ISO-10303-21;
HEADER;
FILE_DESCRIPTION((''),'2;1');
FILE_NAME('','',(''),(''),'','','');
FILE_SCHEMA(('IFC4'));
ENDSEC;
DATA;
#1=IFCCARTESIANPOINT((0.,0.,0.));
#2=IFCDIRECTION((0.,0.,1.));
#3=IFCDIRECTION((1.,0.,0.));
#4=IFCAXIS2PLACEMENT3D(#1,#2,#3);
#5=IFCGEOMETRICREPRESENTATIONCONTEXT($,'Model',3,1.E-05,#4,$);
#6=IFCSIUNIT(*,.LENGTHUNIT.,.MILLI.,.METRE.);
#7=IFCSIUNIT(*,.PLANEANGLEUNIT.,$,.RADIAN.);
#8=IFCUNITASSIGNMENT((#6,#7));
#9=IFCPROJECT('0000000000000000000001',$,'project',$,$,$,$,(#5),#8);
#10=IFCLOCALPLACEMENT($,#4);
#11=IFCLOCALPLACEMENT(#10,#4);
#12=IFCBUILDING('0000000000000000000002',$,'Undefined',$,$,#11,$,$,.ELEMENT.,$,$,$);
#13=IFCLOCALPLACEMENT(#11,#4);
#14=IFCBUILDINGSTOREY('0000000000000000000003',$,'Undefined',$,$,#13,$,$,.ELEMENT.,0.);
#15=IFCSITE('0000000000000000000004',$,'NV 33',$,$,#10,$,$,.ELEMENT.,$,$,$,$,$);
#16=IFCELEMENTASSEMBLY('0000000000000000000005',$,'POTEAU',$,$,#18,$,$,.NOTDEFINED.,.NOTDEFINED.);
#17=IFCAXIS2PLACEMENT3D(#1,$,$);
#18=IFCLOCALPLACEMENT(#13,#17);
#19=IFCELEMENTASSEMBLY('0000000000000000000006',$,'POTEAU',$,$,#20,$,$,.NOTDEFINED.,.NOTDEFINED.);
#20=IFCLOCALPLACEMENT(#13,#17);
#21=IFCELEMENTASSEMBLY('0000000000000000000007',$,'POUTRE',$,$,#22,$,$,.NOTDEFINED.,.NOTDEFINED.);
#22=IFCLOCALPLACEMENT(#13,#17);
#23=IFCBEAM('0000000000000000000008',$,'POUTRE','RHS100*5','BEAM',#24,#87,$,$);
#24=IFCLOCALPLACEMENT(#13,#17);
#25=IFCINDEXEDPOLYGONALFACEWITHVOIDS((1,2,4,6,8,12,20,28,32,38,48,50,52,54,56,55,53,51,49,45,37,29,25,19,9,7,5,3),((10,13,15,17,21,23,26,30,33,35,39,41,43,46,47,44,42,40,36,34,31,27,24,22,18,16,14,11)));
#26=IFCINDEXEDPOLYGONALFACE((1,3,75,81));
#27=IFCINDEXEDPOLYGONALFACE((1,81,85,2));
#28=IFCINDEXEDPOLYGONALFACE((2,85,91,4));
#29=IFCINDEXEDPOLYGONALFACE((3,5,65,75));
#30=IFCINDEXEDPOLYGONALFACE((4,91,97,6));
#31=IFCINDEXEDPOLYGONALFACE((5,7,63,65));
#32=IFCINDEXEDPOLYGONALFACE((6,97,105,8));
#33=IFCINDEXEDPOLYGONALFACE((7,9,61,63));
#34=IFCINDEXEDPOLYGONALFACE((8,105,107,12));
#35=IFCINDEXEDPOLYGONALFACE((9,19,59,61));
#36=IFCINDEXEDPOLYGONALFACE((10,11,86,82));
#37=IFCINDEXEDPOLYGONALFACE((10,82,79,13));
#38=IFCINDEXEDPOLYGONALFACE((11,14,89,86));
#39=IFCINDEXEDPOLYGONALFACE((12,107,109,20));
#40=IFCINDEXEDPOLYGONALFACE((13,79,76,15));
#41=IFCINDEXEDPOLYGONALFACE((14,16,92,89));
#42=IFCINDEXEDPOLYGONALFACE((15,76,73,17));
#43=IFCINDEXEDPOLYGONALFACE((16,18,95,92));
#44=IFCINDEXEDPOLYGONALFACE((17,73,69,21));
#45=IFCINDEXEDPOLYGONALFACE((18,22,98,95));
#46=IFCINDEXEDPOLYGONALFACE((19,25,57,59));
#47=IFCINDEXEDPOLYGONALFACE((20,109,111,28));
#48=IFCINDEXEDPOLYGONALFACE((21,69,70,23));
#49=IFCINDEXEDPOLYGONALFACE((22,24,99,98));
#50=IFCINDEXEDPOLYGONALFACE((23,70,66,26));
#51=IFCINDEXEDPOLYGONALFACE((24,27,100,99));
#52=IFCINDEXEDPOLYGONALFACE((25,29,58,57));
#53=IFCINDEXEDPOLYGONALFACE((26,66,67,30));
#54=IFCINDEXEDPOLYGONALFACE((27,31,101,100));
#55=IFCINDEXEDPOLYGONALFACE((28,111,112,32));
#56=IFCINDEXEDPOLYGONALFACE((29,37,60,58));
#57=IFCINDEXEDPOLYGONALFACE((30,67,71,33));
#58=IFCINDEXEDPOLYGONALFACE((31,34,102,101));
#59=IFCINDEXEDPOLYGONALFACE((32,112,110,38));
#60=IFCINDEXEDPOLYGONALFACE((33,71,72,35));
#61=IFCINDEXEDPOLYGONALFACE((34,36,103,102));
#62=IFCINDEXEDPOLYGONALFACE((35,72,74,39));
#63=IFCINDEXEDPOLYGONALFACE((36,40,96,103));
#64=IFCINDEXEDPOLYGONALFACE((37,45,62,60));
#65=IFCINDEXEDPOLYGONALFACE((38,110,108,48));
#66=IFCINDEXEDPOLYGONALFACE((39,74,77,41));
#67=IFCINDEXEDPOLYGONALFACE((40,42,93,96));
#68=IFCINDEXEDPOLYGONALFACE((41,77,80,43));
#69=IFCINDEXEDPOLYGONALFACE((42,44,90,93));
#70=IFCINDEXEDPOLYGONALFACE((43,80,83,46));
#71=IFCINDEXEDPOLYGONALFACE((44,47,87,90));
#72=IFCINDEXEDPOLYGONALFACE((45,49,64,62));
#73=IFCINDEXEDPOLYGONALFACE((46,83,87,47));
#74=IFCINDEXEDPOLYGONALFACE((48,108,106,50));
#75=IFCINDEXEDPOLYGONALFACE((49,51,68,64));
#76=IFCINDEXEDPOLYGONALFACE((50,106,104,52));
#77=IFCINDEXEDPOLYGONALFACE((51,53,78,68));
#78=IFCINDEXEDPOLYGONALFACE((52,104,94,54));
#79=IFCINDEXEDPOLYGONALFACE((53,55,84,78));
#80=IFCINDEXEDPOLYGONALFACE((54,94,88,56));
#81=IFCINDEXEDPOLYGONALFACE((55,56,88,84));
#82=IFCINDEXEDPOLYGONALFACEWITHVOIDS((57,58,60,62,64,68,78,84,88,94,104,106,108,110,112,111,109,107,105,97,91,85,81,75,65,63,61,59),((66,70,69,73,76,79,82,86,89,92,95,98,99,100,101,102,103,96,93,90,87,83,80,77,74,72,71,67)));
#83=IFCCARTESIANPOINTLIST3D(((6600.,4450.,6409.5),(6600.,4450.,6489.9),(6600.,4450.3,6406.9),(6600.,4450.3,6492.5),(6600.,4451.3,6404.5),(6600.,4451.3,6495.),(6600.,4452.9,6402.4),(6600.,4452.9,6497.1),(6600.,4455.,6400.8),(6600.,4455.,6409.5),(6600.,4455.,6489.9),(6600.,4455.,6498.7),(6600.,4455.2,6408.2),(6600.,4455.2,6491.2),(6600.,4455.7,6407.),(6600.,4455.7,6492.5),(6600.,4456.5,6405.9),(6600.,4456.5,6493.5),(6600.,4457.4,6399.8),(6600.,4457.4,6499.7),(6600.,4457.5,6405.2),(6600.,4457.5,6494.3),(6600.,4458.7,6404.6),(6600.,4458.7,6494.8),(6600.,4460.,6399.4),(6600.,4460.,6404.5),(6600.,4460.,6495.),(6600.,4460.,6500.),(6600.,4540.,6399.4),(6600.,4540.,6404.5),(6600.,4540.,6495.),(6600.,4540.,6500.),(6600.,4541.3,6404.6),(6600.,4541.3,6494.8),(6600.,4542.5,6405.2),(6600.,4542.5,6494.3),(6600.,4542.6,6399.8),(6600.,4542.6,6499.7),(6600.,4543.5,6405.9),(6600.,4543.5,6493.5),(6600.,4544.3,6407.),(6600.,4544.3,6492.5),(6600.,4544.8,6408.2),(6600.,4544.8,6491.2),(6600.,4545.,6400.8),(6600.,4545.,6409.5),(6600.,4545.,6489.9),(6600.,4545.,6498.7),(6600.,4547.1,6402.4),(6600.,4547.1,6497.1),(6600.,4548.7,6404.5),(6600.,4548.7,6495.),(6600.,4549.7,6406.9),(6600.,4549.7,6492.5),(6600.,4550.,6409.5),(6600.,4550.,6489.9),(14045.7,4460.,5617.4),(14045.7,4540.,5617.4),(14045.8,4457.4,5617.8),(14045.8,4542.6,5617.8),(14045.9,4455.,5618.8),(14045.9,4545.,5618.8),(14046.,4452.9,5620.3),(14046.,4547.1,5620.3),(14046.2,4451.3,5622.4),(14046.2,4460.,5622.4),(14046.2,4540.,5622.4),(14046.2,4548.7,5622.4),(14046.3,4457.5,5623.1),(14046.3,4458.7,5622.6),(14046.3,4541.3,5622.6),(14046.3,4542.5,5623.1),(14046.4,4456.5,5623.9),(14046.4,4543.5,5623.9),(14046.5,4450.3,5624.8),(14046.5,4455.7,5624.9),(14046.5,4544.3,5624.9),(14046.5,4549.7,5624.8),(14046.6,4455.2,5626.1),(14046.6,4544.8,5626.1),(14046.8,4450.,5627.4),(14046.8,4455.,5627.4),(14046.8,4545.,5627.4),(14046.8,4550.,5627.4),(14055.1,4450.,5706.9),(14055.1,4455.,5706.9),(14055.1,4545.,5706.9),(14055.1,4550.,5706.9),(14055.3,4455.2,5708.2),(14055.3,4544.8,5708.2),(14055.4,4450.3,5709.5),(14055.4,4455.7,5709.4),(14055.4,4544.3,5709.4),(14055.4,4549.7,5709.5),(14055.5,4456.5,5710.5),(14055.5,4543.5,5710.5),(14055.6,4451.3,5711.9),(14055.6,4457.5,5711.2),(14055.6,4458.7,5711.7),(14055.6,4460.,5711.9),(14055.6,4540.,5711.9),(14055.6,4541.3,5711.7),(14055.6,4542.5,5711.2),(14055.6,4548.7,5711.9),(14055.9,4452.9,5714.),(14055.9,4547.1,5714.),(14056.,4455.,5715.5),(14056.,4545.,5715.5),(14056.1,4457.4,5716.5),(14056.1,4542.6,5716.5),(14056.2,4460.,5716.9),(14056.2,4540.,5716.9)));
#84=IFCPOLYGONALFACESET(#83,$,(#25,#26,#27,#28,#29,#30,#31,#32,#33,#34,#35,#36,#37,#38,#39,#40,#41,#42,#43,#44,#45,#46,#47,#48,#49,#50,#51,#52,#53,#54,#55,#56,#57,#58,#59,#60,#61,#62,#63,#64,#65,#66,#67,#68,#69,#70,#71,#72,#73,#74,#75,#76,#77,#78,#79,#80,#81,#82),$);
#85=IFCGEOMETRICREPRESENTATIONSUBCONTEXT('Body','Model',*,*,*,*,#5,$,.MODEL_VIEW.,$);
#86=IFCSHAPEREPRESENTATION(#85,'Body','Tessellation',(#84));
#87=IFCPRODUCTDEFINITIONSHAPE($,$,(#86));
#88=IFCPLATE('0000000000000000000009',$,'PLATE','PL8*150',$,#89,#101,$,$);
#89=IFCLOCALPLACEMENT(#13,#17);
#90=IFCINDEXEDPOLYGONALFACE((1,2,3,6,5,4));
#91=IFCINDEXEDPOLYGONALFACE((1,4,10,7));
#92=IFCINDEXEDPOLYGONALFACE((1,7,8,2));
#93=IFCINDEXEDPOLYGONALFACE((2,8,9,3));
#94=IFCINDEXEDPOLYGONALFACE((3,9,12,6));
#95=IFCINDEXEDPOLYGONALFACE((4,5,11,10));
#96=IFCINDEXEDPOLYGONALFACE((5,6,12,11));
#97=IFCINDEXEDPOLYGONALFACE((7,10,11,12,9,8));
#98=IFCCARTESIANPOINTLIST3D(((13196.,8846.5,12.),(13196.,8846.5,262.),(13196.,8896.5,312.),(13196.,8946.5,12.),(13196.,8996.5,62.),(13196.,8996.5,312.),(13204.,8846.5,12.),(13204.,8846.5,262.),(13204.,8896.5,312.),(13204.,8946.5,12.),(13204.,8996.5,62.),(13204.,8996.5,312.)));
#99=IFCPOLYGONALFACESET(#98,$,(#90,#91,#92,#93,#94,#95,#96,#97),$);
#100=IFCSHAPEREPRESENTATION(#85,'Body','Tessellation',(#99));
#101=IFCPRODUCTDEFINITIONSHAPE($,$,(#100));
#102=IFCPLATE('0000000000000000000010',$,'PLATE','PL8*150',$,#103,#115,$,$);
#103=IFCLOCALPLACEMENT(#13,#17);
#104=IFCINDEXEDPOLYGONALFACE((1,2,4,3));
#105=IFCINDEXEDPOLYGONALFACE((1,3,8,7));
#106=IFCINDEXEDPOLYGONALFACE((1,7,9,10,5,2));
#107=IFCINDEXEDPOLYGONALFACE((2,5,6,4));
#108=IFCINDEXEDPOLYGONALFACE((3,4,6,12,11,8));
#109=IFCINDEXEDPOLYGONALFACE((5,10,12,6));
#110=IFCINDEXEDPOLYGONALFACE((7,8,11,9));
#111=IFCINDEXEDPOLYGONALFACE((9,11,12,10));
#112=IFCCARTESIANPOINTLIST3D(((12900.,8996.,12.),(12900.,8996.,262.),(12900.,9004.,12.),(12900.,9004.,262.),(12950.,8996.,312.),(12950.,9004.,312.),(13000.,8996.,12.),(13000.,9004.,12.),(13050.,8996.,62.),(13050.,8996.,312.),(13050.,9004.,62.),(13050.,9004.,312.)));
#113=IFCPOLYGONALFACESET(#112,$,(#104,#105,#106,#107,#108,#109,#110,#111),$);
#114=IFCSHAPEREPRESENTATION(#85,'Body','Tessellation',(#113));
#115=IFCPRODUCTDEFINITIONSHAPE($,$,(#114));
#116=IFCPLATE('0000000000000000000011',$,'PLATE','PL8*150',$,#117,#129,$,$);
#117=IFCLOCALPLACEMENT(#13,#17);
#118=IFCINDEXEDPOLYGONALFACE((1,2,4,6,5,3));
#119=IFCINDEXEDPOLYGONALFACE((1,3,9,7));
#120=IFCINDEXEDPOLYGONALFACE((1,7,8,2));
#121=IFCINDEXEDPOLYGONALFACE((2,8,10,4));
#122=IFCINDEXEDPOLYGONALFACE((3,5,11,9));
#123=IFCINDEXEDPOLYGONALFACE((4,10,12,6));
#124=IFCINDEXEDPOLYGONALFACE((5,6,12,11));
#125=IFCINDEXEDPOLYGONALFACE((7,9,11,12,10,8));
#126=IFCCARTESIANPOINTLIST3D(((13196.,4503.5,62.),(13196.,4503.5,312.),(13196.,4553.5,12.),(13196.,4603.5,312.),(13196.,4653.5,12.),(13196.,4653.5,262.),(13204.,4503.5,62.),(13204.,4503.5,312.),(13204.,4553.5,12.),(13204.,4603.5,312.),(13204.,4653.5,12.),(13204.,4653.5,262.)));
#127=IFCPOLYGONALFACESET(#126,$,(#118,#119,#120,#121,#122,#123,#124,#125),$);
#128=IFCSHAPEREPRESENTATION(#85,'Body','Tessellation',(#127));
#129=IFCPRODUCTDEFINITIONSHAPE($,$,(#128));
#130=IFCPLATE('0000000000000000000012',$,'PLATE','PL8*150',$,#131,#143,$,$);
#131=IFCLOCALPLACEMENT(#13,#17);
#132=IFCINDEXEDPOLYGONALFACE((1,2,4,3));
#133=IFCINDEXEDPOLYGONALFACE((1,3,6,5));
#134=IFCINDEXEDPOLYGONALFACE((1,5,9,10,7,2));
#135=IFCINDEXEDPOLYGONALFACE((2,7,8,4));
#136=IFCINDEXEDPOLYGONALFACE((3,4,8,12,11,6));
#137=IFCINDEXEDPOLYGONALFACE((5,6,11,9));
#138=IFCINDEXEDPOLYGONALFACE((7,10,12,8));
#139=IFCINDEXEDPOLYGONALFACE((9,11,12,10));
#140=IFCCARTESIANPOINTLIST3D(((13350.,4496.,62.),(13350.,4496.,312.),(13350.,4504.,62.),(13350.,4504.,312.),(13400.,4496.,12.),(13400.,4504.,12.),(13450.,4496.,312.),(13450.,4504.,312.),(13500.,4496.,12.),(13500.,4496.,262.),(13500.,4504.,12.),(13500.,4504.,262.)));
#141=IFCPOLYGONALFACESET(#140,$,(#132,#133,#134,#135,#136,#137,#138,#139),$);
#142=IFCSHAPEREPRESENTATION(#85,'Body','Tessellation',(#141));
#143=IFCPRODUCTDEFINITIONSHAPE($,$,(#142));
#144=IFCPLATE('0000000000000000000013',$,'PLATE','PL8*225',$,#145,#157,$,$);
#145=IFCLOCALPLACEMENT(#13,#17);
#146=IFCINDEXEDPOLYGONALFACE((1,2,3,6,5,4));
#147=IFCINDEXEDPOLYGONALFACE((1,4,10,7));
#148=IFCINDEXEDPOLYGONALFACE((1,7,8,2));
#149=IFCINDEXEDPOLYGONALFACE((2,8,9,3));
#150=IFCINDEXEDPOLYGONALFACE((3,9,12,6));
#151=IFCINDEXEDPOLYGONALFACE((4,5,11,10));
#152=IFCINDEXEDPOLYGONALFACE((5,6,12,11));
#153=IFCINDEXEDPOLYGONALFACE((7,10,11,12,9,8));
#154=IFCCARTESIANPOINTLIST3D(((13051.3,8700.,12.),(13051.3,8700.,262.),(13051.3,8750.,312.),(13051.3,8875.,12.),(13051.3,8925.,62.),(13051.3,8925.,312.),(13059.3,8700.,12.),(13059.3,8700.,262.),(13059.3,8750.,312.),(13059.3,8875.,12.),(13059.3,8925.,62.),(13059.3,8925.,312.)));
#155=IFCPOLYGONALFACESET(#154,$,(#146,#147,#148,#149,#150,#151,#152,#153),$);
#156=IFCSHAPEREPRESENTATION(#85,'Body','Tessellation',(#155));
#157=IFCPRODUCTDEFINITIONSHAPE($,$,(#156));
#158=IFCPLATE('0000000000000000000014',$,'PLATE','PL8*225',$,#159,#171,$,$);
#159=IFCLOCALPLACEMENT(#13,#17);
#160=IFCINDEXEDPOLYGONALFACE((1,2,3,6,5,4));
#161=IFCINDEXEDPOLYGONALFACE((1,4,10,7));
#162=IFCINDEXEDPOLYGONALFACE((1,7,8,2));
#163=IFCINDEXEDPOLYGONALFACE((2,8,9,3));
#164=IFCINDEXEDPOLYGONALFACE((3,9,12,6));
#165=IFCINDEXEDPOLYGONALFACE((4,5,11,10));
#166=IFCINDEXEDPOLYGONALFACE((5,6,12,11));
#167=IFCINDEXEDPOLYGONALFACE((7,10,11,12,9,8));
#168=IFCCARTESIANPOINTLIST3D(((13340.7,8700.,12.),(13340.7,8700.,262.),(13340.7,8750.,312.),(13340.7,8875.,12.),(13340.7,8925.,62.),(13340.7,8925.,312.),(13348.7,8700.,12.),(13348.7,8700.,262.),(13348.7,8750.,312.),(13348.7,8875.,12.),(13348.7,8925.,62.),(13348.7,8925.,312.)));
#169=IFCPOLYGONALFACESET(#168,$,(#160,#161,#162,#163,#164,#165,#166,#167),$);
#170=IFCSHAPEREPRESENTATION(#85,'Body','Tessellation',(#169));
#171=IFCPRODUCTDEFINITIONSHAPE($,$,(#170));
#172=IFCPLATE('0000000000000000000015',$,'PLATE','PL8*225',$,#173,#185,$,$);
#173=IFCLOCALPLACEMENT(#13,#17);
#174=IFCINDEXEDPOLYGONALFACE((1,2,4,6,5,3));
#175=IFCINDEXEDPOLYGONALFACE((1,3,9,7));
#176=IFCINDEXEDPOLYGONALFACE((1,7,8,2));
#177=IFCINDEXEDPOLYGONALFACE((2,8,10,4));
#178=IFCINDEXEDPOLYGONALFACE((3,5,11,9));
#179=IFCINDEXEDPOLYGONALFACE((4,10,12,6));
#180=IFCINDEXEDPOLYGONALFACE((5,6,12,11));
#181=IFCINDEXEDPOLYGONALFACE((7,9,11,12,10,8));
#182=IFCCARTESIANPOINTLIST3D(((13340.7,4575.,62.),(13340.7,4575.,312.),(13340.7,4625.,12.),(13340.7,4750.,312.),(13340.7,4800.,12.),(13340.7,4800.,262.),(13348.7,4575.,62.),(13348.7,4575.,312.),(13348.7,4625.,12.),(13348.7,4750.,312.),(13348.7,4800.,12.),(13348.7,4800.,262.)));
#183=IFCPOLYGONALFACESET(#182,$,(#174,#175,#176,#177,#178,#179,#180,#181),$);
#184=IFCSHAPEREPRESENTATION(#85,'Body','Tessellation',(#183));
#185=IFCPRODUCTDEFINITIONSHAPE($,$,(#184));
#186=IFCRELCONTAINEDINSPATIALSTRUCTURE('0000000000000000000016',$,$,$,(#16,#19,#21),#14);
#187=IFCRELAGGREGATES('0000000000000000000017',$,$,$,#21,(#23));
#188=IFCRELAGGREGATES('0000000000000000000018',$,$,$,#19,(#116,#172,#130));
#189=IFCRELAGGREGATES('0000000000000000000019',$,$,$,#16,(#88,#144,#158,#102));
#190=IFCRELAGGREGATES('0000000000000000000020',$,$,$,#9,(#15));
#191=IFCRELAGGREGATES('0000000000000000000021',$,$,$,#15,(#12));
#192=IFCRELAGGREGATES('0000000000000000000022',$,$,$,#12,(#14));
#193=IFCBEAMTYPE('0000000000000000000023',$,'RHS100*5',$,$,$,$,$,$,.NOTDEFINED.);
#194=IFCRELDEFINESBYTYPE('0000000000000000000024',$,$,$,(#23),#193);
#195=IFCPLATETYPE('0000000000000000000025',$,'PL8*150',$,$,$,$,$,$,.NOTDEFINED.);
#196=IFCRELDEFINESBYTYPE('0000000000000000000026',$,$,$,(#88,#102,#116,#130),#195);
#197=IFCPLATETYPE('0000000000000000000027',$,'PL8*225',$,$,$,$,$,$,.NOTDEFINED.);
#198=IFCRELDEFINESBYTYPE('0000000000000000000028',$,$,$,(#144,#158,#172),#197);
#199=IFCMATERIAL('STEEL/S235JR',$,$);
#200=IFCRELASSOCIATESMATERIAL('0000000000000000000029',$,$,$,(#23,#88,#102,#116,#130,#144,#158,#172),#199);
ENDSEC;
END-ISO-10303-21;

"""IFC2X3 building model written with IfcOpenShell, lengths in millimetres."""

from ifc_helpers import new_model, si_unit, frame, origin_with_axes, origin_2d_with_axis, place, context, subcontext, project, spatial, polyline, hollow_rectangle, outline, extrude, clip, halfspace, material, type_object, element, aggregate, save


model = new_model("IFC2X3")

# Units and contexts
model_context = context("Model", 3, precision=1e-05, world=origin_with_axes())
body_context = subcontext(model_context, "Body", "Model", "MODEL_VIEW")
ifc_project = project(units=[si_unit("LENGTHUNIT", "METRE", prefix="MILLI"), si_unit("PLANEANGLEUNIT", "RADIAN")], contexts=[model_context])

# Site, building, storey
site_placement = place(None, origin_with_axes())
site = spatial("IfcSite", under=ifc_project, at=site_placement, Name="NV 33", CompositionType="ELEMENT")
building_placement = place(site_placement, origin_with_axes())
building = spatial("IfcBuilding", under=site, at=building_placement, Name="Undefined", CompositionType="ELEMENT")
storey_placement = place(building_placement, origin_with_axes())
storey = spatial("IfcBuildingStorey", under=building, at=storey_placement, Name="Undefined", CompositionType="ELEMENT", Elevation=0.0)

# Element assemblies
assembly_1_placement = place(storey_placement, origin_with_axes())
assembly_1 = element("IfcElementAssembly", 1, at=assembly_1_placement, inside=storey, Name="POTEAU", AssemblyPlace="NOTDEFINED", PredefinedType="NOTDEFINED")
ifc_material_1 = material(Name="STEEL/S235JR")
assembly_2_placement = place(storey_placement, origin_with_axes())
assembly_2 = element("IfcElementAssembly", 2, at=assembly_2_placement, inside=storey, Name="POTEAU", AssemblyPlace="NOTDEFINED", PredefinedType="NOTDEFINED")

# Element assembly, beam
beam_type_1 = type_object("IfcBeamType", Name="RHS100*5", PredefinedType="NOTDEFINED")
assembly_3_placement = place(storey_placement, origin_with_axes())
assembly_3 = element("IfcElementAssembly", 3, at=assembly_3_placement, inside=storey, Name="POUTRE", AssemblyPlace="NOTDEFINED", PredefinedType="NOTDEFINED")
beam_1_placement = place(assembly_3_placement, frame((14050.9, 4500.0, 5667.2), z_axis=(-0.104455, 0.0, -0.99453), x_axis=(-0.99453, 0.0, 0.104455)))
beam_1 = element("IfcBeam", 4, at=beam_1_placement, type_object=beam_type_1, material=ifc_material_1, Name="POUTRE", Description="RHS100*5", ObjectType="BEAM", context=body_context, shape_type="Clipping", body=[
    clip(extrude(hollow_rectangle(XDim=100.0, YDim=100.0, WallThickness=5.0, InnerFilletRadius=5.0, OuterFilletRadius=10.0, at=origin_2d_with_axis()), frame((7527.2, 0.0, 0.0), z_axis=(-1.0, 0.0, 0.0), x_axis=(0.0, -1.0, 0.0)), (0.0, 0.0, 1.0), 7527.2), halfspace(frame((7497.2, 50.0, -50.0), z_axis=(0.99453, 0.0, 0.104455), x_axis=(0.0, -1.0, 0.0)), False)),
])
aggregate(assembly_3, [beam_1])

# Plates
plate_type_1 = type_object("IfcPlateType", Name="PL8*150", PredefinedType="NOTDEFINED")
plate_1_placement = place(assembly_1_placement, frame((13200.0, 8996.5, 12.0), z_axis=(-1.0, 0.0, 0.0), x_axis=(0.0, -1.0, 0.0)))
plate_1 = element("IfcPlate", 5, at=plate_1_placement, type_object=plate_type_1, material=ifc_material_1, Name="PLATE", Description="PL8*150", context=body_context, shape_type="SweptSolid", body=[
    extrude(outline(polyline([(0.0, 50.0), (50.0, 0.0), (150.0, 0.0), (150.0, 250.0), (100.0, 300.0), (0.0, 300.0), (0.0, 50.0)])), frame((0.0, 0.0, -4.0), z_axis=(0.0, 0.0, 1.0), x_axis=(1.0, 0.0, 0.0)), (0.0, 0.0, 1.0), 8.0),
])
plate_2_placement = place(assembly_1_placement, frame((13050.0, 9000.0, 12.0), z_axis=(0.0, 1.0, 0.0), x_axis=(-1.0, 0.0, 0.0)))
plate_2 = element("IfcPlate", 6, at=plate_2_placement, type_object=plate_type_1, material=ifc_material_1, Name="PLATE", Description="PL8*150", context=body_context, shape_type="SweptSolid", body=[
    extrude(outline(polyline([(0.0, 50.0), (50.0, 0.0), (150.0, 0.0), (150.0, 250.0), (100.0, 300.0), (0.0, 300.0), (0.0, 50.0)])), frame((0.0, 0.0, -4.0), z_axis=(0.0, 0.0, 1.0), x_axis=(1.0, 0.0, 0.0)), (0.0, 0.0, 1.0), 8.0),
])
plate_3_placement = place(assembly_2_placement, frame((13200.0, 4503.5, 12.0), z_axis=(1.0, 0.0, 0.0), x_axis=(0.0, 1.0, 0.0)))
plate_3 = element("IfcPlate", 7, at=plate_3_placement, type_object=plate_type_1, material=ifc_material_1, Name="PLATE", Description="PL8*150", context=body_context, shape_type="SweptSolid", body=[
    extrude(outline(polyline([(0.0, 50.0), (50.0, 0.0), (150.0, 0.0), (150.0, 250.0), (100.0, 300.0), (0.0, 300.0), (0.0, 50.0)])), frame((0.0, 0.0, -4.0), z_axis=(0.0, 0.0, 1.0), x_axis=(1.0, 0.0, 0.0)), (0.0, 0.0, 1.0), 8.0),
])
plate_4_placement = place(assembly_2_placement, frame((13350.0, 4500.0, 12.0), z_axis=(0.0, -1.0, 0.0), x_axis=(1.0, 0.0, 0.0)))
plate_4 = element("IfcPlate", 8, at=plate_4_placement, type_object=plate_type_1, material=ifc_material_1, Name="PLATE", Description="PL8*150", context=body_context, shape_type="SweptSolid", body=[
    extrude(outline(polyline([(0.0, 50.0), (50.0, 0.0), (150.0, 0.0), (150.0, 250.0), (100.0, 300.0), (0.0, 300.0), (0.0, 50.0)])), frame((0.0, 0.0, -4.0), z_axis=(0.0, 0.0, 1.0), x_axis=(1.0, 0.0, 0.0)), (0.0, 0.0, 1.0), 8.0),
])
plate_type_2 = type_object("IfcPlateType", Name="PL8*225", PredefinedType="NOTDEFINED")
plate_5_placement = place(assembly_1_placement, frame((13055.3, 8925.0, 12.0), z_axis=(-1.0, 0.0, 0.0), x_axis=(0.0, -1.0, 0.0)))
plate_5 = element("IfcPlate", 9, at=plate_5_placement, type_object=plate_type_2, material=ifc_material_1, Name="PLATE", Description="PL8*225", context=body_context, shape_type="SweptSolid", body=[
    extrude(outline(polyline([(0.0, 50.0), (50.0, 0.0), (225.0, 0.0), (225.0, 250.0), (175.0, 300.0), (0.0, 300.0), (0.0, 50.0)])), frame((0.0, 0.0, -4.0), z_axis=(0.0, 0.0, 1.0), x_axis=(1.0, 0.0, 0.0)), (0.0, 0.0, 1.0), 8.0),
])
plate_6_placement = place(assembly_1_placement, frame((13344.7, 8925.0, 12.0), z_axis=(-1.0, 0.0, 0.0), x_axis=(0.0, -1.0, 0.0)))
plate_6 = element("IfcPlate", 10, at=plate_6_placement, type_object=plate_type_2, material=ifc_material_1, Name="PLATE", Description="PL8*225", context=body_context, shape_type="SweptSolid", body=[
    extrude(outline(polyline([(0.0, 50.0), (50.0, 0.0), (225.0, 0.0), (225.0, 250.0), (175.0, 300.0), (0.0, 300.0), (0.0, 50.0)])), frame((0.0, 0.0, -4.0), z_axis=(0.0, 0.0, 1.0), x_axis=(1.0, 0.0, 0.0)), (0.0, 0.0, 1.0), 8.0),
])
plate_7_placement = place(assembly_2_placement, frame((13344.7, 4575.0, 12.0), z_axis=(1.0, 0.0, 0.0), x_axis=(0.0, 1.0, 0.0)))
plate_7 = element("IfcPlate", 11, at=plate_7_placement, type_object=plate_type_2, material=ifc_material_1, Name="PLATE", Description="PL8*225", context=body_context, shape_type="SweptSolid", body=[
    extrude(outline(polyline([(0.0, 50.0), (50.0, 0.0), (225.0, 0.0), (225.0, 250.0), (175.0, 300.0), (0.0, 300.0), (0.0, 50.0)])), frame((0.0, 0.0, -4.0), z_axis=(0.0, 0.0, 1.0), x_axis=(1.0, 0.0, 0.0)), (0.0, 0.0, 1.0), 8.0),
])
aggregate(assembly_2, [plate_3, plate_7, plate_4])

aggregate(assembly_1, [plate_1, plate_5, plate_6, plate_2])

save(model, "model.ifc")
